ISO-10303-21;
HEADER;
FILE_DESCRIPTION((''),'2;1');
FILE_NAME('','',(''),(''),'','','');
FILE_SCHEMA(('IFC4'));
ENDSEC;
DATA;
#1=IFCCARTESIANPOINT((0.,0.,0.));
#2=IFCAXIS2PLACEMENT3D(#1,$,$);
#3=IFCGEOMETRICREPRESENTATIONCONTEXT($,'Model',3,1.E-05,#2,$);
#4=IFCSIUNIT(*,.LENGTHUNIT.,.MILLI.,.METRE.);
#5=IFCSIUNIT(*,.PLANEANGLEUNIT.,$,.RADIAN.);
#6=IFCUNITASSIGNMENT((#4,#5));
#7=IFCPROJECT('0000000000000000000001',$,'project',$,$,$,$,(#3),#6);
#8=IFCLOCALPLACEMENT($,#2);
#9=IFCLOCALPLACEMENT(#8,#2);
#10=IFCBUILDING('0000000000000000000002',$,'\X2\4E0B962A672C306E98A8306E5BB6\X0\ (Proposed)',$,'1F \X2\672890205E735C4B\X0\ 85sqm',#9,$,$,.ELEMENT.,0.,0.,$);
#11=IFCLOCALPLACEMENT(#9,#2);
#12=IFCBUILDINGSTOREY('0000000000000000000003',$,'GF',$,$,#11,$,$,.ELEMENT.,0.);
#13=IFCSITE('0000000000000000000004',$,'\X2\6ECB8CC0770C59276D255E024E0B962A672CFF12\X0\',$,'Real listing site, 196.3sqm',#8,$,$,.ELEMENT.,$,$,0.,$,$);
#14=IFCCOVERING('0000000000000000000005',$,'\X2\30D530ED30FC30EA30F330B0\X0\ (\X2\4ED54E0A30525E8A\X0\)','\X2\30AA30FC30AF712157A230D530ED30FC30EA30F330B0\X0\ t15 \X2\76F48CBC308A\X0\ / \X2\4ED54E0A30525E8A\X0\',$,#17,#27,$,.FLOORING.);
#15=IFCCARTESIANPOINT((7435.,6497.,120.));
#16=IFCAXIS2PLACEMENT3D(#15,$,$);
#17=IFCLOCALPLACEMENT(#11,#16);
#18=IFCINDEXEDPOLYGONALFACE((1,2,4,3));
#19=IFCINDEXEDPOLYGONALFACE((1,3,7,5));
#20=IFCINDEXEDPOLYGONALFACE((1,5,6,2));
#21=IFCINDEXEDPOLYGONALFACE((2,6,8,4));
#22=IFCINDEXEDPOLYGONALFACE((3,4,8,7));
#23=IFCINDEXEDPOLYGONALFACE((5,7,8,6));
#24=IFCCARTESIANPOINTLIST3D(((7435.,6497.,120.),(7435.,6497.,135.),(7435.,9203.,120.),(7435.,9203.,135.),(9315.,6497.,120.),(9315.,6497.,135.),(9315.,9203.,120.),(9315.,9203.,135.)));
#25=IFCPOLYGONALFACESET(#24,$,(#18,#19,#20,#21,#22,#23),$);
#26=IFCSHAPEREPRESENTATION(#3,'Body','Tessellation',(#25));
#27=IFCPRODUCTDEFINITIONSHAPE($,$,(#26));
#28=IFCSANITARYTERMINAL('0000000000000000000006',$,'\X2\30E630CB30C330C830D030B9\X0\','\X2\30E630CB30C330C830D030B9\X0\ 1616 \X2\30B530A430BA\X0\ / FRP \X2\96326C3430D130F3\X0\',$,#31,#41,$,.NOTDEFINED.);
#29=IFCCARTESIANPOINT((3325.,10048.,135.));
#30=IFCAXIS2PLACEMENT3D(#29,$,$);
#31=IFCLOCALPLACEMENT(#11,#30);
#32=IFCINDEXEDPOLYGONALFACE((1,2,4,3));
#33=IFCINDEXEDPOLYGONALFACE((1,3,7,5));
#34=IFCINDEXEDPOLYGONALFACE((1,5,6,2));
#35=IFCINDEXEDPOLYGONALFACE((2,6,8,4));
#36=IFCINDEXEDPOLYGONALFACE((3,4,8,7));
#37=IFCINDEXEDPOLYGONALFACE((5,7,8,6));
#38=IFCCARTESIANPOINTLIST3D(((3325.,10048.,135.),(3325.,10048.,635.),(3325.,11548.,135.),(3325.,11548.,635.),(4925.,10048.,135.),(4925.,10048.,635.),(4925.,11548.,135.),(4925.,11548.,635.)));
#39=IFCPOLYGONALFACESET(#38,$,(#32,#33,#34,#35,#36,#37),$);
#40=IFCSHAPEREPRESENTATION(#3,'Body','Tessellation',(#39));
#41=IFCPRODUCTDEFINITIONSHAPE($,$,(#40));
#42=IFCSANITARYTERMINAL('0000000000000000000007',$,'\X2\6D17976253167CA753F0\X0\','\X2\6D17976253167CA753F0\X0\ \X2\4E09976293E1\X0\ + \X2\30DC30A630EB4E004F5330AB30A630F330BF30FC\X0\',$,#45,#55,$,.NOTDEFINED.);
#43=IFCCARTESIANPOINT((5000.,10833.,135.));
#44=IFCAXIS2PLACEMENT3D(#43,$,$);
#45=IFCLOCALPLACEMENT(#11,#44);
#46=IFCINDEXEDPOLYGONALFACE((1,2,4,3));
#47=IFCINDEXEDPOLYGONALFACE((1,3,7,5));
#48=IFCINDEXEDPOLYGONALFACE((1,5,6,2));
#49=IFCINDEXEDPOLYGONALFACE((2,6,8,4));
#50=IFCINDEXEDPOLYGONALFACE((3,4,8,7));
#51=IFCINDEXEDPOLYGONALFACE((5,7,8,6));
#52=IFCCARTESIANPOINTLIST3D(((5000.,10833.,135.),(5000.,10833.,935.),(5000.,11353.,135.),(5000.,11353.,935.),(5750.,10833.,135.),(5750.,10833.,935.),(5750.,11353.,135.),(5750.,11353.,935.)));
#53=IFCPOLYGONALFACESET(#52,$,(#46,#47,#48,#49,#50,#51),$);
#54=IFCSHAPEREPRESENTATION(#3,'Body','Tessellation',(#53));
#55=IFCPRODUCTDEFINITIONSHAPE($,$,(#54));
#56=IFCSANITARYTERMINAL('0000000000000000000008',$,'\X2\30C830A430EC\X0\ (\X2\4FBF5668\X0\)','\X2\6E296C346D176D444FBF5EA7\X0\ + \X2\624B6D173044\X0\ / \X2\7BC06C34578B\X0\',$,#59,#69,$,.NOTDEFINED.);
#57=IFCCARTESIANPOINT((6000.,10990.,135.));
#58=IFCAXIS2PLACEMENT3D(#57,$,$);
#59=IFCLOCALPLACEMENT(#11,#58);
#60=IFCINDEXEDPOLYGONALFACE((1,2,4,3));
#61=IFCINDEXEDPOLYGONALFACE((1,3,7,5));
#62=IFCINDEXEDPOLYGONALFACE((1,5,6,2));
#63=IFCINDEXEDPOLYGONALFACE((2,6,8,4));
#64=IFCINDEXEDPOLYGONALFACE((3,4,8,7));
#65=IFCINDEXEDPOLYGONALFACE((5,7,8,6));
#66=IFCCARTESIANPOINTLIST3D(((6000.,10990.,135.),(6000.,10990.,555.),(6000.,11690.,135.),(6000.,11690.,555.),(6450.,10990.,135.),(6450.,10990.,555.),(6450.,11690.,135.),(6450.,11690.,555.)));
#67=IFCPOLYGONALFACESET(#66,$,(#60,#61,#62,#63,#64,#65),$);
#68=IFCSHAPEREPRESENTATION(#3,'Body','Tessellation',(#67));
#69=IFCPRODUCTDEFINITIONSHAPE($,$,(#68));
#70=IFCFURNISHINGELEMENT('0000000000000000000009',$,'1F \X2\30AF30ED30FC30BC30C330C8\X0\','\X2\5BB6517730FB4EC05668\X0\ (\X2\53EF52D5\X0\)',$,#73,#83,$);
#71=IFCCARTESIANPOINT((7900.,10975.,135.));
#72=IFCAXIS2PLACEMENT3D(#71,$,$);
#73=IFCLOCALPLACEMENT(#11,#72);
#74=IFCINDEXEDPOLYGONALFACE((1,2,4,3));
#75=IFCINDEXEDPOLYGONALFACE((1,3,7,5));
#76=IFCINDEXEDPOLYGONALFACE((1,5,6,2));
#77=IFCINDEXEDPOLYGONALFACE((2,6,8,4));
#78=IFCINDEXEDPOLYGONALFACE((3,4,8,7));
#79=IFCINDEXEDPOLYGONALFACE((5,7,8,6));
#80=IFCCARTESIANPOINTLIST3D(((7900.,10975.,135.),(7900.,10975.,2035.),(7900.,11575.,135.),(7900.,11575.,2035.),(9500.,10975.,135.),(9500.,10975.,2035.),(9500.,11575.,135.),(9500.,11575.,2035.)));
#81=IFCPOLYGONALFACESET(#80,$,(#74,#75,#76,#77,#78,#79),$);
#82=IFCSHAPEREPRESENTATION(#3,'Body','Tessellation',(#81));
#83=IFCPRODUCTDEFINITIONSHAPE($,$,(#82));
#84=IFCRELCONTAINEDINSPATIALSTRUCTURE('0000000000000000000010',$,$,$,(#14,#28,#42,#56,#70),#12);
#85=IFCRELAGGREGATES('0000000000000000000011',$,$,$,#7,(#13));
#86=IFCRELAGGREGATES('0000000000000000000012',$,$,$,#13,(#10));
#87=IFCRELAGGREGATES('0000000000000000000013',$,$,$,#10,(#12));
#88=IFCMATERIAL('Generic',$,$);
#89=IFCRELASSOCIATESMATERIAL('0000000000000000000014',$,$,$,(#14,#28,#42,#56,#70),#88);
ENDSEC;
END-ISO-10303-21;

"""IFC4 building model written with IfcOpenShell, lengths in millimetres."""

from ifc_helpers import new_model, si_unit, frame, frame_2d, origin, place, context, project, spatial, rectangle, extrude, material, element, save


model = new_model("IFC4")

# Units and contexts
model_context = context("Model", 3, precision=1e-05, world=origin())
ifc_project = project(units=[si_unit("LENGTHUNIT", "METRE", prefix="MILLI"), si_unit("PLANEANGLEUNIT", "RADIAN")], contexts=[model_context])

# Site, building, storey
site_placement = place(None, origin())
site = spatial("IfcSite", under=ifc_project, at=site_placement, Name="滋賀県大津市下阪本２", ObjectType="Real listing site, 196.3sqm", CompositionType="ELEMENT", RefElevation=0.0)
building_placement = place(site_placement, origin())
building = spatial("IfcBuilding", under=site, at=building_placement, Name="下阪本の風の家 (Proposed)", ObjectType="1F 木造平屋 85sqm", CompositionType="ELEMENT", ElevationOfRefHeight=0.0, ElevationOfTerrain=0.0)
storey_placement = place(building_placement, origin())
storey = spatial("IfcBuildingStorey", under=building, at=storey_placement, Name="GF", CompositionType="ELEMENT", Elevation=0.0)

# Covering
ifc_material_1 = material(Name="Generic")
covering_1_placement = place(storey_placement, frame((7435.0, 6497.0, 120.0)))
element("IfcCovering", 1, at=covering_1_placement, inside=storey, material=ifc_material_1, Name="フローリング (仕上げ床)", Description="オーク無垢フローリング t15 直貼り / 仕上げ床", PredefinedType="FLOORING", context=model_context, shape_type="SweptSolid", body=[
    extrude(rectangle(XDim=1880.0, YDim=2706.0, at=frame_2d((940.0, 1353.0))), frame((7435.0, 6497.0, 120.0)), (0.0, 0.0, 1.0), 15.0),
])

# Sanitary terminals
sanitary_terminal_1_placement = place(storey_placement, frame((3325.0, 10048.0, 135.0)))
element("IfcSanitaryTerminal", 2, at=sanitary_terminal_1_placement, inside=storey, material=ifc_material_1, Name="ユニットバス", Description="ユニットバス 1616 サイズ / FRP 防水パン", PredefinedType="NOTDEFINED", context=model_context, shape_type="SweptSolid", body=[
    extrude(rectangle(XDim=1600.0, YDim=1500.0, at=frame_2d((800.0, 750.0))), frame((3325.0, 10048.0, 135.0)), (0.0, 0.0, 1.0), 500.0),
])
sanitary_terminal_2_placement = place(storey_placement, frame((5000.0, 10833.0, 135.0)))
element("IfcSanitaryTerminal", 3, at=sanitary_terminal_2_placement, inside=storey, material=ifc_material_1, Name="洗面化粧台", Description="洗面化粧台 三面鏡 + ボウル一体カウンター", PredefinedType="NOTDEFINED", context=model_context, shape_type="SweptSolid", body=[
    extrude(rectangle(XDim=750.0, YDim=520.0, at=frame_2d((375.0, 260.0))), frame((5000.0, 10833.0, 135.0)), (0.0, 0.0, 1.0), 800.0),
])
sanitary_terminal_3_placement = place(storey_placement, frame((6000.0, 10990.0, 135.0)))
element("IfcSanitaryTerminal", 4, at=sanitary_terminal_3_placement, inside=storey, material=ifc_material_1, Name="トイレ (便器)", Description="温水洗浄便座 + 手洗い / 節水型", PredefinedType="NOTDEFINED", context=model_context, shape_type="SweptSolid", body=[
    extrude(rectangle(XDim=450.0, YDim=700.0, at=frame_2d((225.0, 350.0))), frame((6000.0, 10990.0, 135.0)), (0.0, 0.0, 1.0), 420.0),
])

# Furnishing element
furnishing_placement = place(storey_placement, frame((7900.0, 10975.0, 135.0)))
element("IfcFurnishingElement", 5, at=furnishing_placement, inside=storey, material=ifc_material_1, Name="1F クローゼット", Description="家具・什器 (可動)", context=model_context, shape_type="SweptSolid", body=[
    extrude(rectangle(XDim=1600.0, YDim=600.0, at=frame_2d((800.0, 300.0))), frame((7900.0, 10975.0, 135.0)), (0.0, 0.0, 1.0), 1900.0),
])

save(model, "model.ifc")
